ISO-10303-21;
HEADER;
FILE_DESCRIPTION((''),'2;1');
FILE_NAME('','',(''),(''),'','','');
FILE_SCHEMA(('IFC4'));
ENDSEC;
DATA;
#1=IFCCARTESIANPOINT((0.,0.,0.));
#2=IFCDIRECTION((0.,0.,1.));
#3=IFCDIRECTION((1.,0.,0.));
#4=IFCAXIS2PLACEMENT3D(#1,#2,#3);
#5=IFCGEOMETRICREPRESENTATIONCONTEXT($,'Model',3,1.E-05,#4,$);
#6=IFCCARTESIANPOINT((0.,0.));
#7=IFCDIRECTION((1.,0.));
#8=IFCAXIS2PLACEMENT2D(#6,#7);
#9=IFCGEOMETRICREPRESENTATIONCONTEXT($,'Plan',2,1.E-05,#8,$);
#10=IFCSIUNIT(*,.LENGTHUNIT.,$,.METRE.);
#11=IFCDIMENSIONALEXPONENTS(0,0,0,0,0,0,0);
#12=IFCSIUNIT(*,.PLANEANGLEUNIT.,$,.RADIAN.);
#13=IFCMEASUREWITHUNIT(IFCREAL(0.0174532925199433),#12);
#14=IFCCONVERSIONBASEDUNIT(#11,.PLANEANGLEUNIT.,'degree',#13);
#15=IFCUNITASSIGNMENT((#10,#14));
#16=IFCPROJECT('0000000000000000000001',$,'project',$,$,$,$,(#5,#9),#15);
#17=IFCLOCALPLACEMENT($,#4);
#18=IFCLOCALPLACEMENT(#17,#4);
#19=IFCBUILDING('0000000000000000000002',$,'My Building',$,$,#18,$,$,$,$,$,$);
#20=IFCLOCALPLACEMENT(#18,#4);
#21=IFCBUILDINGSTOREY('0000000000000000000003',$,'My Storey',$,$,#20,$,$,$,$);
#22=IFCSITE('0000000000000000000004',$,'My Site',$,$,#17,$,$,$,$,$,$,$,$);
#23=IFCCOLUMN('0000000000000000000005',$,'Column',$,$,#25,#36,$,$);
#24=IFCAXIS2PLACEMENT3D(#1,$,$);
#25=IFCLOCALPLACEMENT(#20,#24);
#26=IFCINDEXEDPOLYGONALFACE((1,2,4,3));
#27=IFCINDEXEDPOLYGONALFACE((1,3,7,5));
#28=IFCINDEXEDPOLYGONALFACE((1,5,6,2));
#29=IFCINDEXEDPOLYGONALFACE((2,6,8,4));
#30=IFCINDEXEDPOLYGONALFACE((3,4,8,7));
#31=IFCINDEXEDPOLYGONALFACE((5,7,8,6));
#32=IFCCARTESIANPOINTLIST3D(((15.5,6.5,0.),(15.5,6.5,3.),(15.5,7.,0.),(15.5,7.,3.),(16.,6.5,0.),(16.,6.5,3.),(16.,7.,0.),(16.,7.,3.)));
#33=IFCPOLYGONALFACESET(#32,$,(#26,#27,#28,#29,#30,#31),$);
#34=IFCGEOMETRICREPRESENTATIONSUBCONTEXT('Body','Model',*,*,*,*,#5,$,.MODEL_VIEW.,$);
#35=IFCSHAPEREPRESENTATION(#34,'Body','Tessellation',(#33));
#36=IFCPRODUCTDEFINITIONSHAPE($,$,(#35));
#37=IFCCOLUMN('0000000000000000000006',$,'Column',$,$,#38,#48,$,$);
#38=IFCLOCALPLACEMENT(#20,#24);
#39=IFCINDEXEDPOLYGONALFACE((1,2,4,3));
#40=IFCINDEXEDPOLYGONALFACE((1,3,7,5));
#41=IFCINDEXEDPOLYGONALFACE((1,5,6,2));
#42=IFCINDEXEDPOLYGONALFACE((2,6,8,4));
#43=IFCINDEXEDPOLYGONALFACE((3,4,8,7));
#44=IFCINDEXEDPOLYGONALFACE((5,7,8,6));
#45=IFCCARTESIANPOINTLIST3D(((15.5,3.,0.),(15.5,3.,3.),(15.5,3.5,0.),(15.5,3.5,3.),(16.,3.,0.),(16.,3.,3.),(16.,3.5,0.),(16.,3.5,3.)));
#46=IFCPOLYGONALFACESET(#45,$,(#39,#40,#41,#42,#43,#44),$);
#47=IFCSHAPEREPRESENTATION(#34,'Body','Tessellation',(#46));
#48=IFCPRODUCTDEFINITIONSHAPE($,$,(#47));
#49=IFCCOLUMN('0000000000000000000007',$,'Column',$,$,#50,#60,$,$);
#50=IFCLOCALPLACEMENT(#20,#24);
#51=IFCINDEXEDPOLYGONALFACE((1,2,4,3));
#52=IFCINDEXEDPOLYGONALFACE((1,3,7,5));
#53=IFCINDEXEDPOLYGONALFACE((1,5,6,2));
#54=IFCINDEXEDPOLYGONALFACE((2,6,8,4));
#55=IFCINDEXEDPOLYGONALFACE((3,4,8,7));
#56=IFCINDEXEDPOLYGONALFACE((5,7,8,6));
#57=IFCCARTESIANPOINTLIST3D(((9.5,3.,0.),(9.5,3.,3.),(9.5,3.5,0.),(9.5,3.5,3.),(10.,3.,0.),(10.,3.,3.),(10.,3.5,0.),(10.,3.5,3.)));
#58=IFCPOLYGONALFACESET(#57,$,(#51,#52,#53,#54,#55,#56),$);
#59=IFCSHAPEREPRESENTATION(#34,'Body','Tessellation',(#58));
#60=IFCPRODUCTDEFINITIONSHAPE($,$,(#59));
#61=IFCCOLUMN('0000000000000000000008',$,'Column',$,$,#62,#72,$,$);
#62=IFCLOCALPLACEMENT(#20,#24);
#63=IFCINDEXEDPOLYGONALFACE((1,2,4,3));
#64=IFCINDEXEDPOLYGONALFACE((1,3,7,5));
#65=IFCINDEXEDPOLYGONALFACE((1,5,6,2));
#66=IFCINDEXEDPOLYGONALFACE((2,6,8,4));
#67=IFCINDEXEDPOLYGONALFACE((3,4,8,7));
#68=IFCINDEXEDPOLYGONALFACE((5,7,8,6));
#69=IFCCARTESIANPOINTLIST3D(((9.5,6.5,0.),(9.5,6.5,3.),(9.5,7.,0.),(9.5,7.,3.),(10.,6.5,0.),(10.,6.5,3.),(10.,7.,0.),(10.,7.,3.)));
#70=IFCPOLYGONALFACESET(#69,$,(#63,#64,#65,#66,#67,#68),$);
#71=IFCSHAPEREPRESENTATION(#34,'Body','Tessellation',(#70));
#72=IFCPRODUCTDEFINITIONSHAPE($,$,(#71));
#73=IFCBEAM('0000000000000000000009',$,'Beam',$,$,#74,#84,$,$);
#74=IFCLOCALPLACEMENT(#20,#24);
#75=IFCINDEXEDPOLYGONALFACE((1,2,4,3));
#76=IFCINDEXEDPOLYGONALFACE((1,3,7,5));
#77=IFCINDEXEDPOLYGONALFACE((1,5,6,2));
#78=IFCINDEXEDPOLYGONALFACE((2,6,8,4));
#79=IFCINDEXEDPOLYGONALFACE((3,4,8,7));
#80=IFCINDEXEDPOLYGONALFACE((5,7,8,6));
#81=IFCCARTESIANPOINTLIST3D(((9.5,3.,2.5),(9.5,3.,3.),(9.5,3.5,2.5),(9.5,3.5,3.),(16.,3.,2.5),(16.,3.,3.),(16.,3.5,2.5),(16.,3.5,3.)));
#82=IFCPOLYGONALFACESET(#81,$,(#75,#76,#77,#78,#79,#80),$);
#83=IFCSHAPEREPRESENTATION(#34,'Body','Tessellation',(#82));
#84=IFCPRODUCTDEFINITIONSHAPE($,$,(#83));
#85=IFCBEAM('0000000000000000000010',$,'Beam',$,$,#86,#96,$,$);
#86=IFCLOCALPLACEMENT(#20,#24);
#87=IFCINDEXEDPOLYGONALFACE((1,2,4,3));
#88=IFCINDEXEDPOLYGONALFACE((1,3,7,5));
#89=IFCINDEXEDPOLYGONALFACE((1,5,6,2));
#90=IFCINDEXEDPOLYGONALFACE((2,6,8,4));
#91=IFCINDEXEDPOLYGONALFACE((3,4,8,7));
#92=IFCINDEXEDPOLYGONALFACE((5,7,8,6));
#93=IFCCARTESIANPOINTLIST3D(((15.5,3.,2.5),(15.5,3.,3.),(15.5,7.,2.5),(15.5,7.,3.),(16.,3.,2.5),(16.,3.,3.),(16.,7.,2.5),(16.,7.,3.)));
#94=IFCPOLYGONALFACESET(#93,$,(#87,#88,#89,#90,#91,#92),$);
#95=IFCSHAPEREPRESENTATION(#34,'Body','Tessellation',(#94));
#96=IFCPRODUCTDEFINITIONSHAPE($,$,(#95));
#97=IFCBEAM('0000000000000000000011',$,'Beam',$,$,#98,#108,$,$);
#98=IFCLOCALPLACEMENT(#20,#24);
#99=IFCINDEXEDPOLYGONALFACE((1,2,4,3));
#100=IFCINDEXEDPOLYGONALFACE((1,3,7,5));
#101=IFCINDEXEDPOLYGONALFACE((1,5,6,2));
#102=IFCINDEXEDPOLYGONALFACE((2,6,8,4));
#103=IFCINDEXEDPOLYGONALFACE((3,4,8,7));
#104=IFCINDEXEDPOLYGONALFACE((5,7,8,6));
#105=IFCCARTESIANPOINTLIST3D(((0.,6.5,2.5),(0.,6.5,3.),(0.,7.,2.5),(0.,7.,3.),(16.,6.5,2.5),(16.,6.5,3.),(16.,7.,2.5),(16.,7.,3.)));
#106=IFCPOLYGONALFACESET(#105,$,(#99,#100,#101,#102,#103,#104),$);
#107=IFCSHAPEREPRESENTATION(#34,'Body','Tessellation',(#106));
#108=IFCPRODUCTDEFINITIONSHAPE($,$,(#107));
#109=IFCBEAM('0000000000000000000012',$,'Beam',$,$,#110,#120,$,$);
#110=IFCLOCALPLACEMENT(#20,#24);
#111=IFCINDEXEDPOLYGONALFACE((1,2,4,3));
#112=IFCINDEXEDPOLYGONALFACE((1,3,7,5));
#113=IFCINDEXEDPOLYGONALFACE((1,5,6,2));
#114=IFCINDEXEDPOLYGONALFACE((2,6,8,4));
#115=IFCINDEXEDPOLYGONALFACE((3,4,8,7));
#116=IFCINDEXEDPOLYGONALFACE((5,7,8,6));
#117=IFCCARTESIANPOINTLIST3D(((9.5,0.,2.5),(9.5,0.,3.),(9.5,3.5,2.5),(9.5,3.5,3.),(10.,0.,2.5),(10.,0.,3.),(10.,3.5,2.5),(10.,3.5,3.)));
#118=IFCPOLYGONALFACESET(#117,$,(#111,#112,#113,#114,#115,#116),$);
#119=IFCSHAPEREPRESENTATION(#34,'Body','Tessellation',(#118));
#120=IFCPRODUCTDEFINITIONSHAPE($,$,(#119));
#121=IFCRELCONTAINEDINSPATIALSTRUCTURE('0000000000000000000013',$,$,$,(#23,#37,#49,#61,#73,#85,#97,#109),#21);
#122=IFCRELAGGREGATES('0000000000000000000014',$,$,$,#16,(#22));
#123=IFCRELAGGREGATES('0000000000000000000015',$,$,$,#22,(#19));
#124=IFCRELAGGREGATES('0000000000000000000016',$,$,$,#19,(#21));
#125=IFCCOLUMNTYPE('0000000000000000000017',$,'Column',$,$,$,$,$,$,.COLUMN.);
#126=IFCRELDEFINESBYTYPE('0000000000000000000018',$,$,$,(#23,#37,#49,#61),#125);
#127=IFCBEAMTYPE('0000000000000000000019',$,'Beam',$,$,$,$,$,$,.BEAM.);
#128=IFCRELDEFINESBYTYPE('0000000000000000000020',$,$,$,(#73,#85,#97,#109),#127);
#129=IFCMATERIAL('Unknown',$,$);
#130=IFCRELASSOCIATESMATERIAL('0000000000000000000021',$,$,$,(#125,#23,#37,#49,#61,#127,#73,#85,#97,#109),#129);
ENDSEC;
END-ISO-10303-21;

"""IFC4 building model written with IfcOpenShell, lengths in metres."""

from ifc_helpers import new_model, entity, si_unit, converted_unit, frame, origin_with_axes, origin_2d_with_axis, place, context, subcontext, project, spatial, rectangle, extrude, material, material_profile, profile_set, profile_usage, type_object, element, save


model = new_model("IFC4")

# Units and contexts
model_context = context("Model", 3, precision=1e-05, world=origin_with_axes())
plan_context = context("Plan", 2, precision=1e-05, world=origin_2d_with_axis())
body_context_1 = subcontext(model_context, "Body", "Model", "MODEL_VIEW")
ifc_project = project(units=[si_unit("LENGTHUNIT", "METRE"), converted_unit("PLANEANGLEUNIT", "degree", entity("IfcReal", 0.0174532925199433), si_unit("PLANEANGLEUNIT", "RADIAN"), dimensions=[0, 0, 0, 0, 0, 0, 0])], contexts=[model_context, plan_context])

# Site, building, storey
site_placement = place(None, origin_with_axes())
site = spatial("IfcSite", under=ifc_project, at=site_placement, Name="My Site")
building_placement = place(site_placement, origin_with_axes())
building = spatial("IfcBuilding", under=site, at=building_placement, Name="My Building")
storey_placement = place(building_placement, origin_with_axes())
storey = spatial("IfcBuildingStorey", under=building, at=storey_placement, Name="My Storey")

# Columns
ifc_material = material(Name="Unknown")
ifc_material_profile_1 = material_profile(ifc_material, rectangle(XDim=0.5, YDim=0.5))
ifc_profile_set_1 = profile_set([ifc_material_profile_1])
ifc_profile_usage_1 = profile_usage(ifc_profile_set_1, cardinal=5)
column_type = type_object("IfcColumnType", Name="Column", PredefinedType="COLUMN", material=ifc_profile_set_1)
column_1_placement = place(storey_placement, frame((15.75, 6.75, 0.0), z_axis=(0.0, 0.0, 1.0), x_axis=(1.0, 0.0, 0.0)))
element("IfcColumn", 1, at=column_1_placement, inside=storey, type_object=column_type, material=ifc_profile_usage_1, Name="Column", context=body_context_1, shape_type="SweptSolid", body=[
    extrude(rectangle(XDim=0.5, YDim=0.5), origin_with_axes(), (0.0, 0.0, 1.0), 3.0),
])
ifc_profile_usage_2 = profile_usage(ifc_profile_set_1, cardinal=5)
column_2_placement = place(storey_placement, frame((15.75, 3.25, 0.0), z_axis=(0.0, 0.0, 1.0), x_axis=(1.0, 0.0, 0.0)))
element("IfcColumn", 2, at=column_2_placement, inside=storey, type_object=column_type, material=ifc_profile_usage_2, Name="Column", context=body_context_1, shape_type="SweptSolid", body=[
    extrude(rectangle(XDim=0.5, YDim=0.5), origin_with_axes(), (0.0, 0.0, 1.0), 3.0),
])
ifc_profile_usage_3 = profile_usage(ifc_profile_set_1, cardinal=5)
column_3_placement = place(storey_placement, frame((9.75, 3.25, 0.0), z_axis=(0.0, 0.0, 1.0), x_axis=(1.0, 0.0, 0.0)))
element("IfcColumn", 3, at=column_3_placement, inside=storey, type_object=column_type, material=ifc_profile_usage_3, Name="Column", context=body_context_1, shape_type="SweptSolid", body=[
    extrude(rectangle(XDim=0.5, YDim=0.5), origin_with_axes(), (0.0, 0.0, 1.0), 3.0),
])
ifc_profile_usage_4 = profile_usage(ifc_profile_set_1, cardinal=5)
column_4_placement = place(storey_placement, frame((9.75, 6.75, 0.0), z_axis=(0.0, 0.0, 1.0), x_axis=(1.0, 0.0, 0.0)))
element("IfcColumn", 4, at=column_4_placement, inside=storey, type_object=column_type, material=ifc_profile_usage_4, Name="Column", context=body_context_1, shape_type="SweptSolid", body=[
    extrude(rectangle(XDim=0.5, YDim=0.5), origin_with_axes(), (0.0, 0.0, 1.0), 3.0),
])

# Beams
ifc_material_profile_2 = material_profile(ifc_material, rectangle(XDim=0.5, YDim=0.5))
ifc_profile_set_2 = profile_set([ifc_material_profile_2])
ifc_profile_usage_5 = profile_usage(ifc_profile_set_2, cardinal=8)
beam_type = type_object("IfcBeamType", Name="Beam", PredefinedType="BEAM", material=ifc_profile_set_2)
beam_1_placement = place(storey_placement, frame((16.0, 3.25, 3.0), z_axis=(-1.0, 0.0, 0.0), x_axis=(0.0, -1.0, 0.0)))
element("IfcBeam", 5, at=beam_1_placement, inside=storey, type_object=beam_type, material=ifc_profile_usage_5, Name="Beam", context=body_context_1, shape_type="SweptSolid", body=[
    extrude(rectangle(XDim=0.5, YDim=0.5), frame((0.0, -0.25, 0.0), z_axis=(0.0, 0.0, 1.0), x_axis=(1.0, 0.0, 0.0)), (0.0, 0.0, 1.0), 6.5),
])
ifc_profile_usage_6 = profile_usage(ifc_profile_set_2, cardinal=8)
beam_2_placement = place(storey_placement, frame((15.75, 3.0, 3.0), z_axis=(0.0, 1.0, 0.0), x_axis=(-1.0, 0.0, 0.0)))
element("IfcBeam", 6, at=beam_2_placement, inside=storey, type_object=beam_type, material=ifc_profile_usage_6, Name="Beam", context=body_context_1, shape_type="SweptSolid", body=[
    extrude(rectangle(XDim=0.5, YDim=0.5), frame((0.0, -0.25, 0.0), z_axis=(0.0, 0.0, 1.0), x_axis=(1.0, 0.0, 0.0)), (0.0, 0.0, 1.0), 4.0),
])
ifc_profile_usage_7 = profile_usage(ifc_profile_set_2, cardinal=8)
beam_3_placement = place(storey_placement, frame((16.0, 6.75, 3.0), z_axis=(-1.0, 0.0, 0.0), x_axis=(0.0, -1.0, 0.0)))
element("IfcBeam", 7, at=beam_3_placement, inside=storey, type_object=beam_type, material=ifc_profile_usage_7, Name="Beam", context=body_context_1, shape_type="SweptSolid", body=[
    extrude(rectangle(XDim=0.5, YDim=0.5), frame((0.0, -0.25, 0.0), z_axis=(0.0, 0.0, 1.0), x_axis=(1.0, 0.0, 0.0)), (0.0, 0.0, 1.0), 16.0),
])
ifc_profile_usage_8 = profile_usage(ifc_profile_set_2, cardinal=8)
beam_4_placement = place(storey_placement, frame((9.75, 3.5, 3.0), z_axis=(0.0, -1.0, 0.0), x_axis=(1.0, 0.0, 0.0)))
element("IfcBeam", 8, at=beam_4_placement, inside=storey, type_object=beam_type, material=ifc_profile_usage_8, Name="Beam", context=body_context_1, shape_type="SweptSolid", body=[
    extrude(rectangle(XDim=0.5, YDim=0.5), frame((0.0, -0.25, 0.0), z_axis=(0.0, 0.0, 1.0), x_axis=(1.0, 0.0, 0.0)), (0.0, 0.0, 1.0), 3.5),
])

save(model, "model.ifc")
